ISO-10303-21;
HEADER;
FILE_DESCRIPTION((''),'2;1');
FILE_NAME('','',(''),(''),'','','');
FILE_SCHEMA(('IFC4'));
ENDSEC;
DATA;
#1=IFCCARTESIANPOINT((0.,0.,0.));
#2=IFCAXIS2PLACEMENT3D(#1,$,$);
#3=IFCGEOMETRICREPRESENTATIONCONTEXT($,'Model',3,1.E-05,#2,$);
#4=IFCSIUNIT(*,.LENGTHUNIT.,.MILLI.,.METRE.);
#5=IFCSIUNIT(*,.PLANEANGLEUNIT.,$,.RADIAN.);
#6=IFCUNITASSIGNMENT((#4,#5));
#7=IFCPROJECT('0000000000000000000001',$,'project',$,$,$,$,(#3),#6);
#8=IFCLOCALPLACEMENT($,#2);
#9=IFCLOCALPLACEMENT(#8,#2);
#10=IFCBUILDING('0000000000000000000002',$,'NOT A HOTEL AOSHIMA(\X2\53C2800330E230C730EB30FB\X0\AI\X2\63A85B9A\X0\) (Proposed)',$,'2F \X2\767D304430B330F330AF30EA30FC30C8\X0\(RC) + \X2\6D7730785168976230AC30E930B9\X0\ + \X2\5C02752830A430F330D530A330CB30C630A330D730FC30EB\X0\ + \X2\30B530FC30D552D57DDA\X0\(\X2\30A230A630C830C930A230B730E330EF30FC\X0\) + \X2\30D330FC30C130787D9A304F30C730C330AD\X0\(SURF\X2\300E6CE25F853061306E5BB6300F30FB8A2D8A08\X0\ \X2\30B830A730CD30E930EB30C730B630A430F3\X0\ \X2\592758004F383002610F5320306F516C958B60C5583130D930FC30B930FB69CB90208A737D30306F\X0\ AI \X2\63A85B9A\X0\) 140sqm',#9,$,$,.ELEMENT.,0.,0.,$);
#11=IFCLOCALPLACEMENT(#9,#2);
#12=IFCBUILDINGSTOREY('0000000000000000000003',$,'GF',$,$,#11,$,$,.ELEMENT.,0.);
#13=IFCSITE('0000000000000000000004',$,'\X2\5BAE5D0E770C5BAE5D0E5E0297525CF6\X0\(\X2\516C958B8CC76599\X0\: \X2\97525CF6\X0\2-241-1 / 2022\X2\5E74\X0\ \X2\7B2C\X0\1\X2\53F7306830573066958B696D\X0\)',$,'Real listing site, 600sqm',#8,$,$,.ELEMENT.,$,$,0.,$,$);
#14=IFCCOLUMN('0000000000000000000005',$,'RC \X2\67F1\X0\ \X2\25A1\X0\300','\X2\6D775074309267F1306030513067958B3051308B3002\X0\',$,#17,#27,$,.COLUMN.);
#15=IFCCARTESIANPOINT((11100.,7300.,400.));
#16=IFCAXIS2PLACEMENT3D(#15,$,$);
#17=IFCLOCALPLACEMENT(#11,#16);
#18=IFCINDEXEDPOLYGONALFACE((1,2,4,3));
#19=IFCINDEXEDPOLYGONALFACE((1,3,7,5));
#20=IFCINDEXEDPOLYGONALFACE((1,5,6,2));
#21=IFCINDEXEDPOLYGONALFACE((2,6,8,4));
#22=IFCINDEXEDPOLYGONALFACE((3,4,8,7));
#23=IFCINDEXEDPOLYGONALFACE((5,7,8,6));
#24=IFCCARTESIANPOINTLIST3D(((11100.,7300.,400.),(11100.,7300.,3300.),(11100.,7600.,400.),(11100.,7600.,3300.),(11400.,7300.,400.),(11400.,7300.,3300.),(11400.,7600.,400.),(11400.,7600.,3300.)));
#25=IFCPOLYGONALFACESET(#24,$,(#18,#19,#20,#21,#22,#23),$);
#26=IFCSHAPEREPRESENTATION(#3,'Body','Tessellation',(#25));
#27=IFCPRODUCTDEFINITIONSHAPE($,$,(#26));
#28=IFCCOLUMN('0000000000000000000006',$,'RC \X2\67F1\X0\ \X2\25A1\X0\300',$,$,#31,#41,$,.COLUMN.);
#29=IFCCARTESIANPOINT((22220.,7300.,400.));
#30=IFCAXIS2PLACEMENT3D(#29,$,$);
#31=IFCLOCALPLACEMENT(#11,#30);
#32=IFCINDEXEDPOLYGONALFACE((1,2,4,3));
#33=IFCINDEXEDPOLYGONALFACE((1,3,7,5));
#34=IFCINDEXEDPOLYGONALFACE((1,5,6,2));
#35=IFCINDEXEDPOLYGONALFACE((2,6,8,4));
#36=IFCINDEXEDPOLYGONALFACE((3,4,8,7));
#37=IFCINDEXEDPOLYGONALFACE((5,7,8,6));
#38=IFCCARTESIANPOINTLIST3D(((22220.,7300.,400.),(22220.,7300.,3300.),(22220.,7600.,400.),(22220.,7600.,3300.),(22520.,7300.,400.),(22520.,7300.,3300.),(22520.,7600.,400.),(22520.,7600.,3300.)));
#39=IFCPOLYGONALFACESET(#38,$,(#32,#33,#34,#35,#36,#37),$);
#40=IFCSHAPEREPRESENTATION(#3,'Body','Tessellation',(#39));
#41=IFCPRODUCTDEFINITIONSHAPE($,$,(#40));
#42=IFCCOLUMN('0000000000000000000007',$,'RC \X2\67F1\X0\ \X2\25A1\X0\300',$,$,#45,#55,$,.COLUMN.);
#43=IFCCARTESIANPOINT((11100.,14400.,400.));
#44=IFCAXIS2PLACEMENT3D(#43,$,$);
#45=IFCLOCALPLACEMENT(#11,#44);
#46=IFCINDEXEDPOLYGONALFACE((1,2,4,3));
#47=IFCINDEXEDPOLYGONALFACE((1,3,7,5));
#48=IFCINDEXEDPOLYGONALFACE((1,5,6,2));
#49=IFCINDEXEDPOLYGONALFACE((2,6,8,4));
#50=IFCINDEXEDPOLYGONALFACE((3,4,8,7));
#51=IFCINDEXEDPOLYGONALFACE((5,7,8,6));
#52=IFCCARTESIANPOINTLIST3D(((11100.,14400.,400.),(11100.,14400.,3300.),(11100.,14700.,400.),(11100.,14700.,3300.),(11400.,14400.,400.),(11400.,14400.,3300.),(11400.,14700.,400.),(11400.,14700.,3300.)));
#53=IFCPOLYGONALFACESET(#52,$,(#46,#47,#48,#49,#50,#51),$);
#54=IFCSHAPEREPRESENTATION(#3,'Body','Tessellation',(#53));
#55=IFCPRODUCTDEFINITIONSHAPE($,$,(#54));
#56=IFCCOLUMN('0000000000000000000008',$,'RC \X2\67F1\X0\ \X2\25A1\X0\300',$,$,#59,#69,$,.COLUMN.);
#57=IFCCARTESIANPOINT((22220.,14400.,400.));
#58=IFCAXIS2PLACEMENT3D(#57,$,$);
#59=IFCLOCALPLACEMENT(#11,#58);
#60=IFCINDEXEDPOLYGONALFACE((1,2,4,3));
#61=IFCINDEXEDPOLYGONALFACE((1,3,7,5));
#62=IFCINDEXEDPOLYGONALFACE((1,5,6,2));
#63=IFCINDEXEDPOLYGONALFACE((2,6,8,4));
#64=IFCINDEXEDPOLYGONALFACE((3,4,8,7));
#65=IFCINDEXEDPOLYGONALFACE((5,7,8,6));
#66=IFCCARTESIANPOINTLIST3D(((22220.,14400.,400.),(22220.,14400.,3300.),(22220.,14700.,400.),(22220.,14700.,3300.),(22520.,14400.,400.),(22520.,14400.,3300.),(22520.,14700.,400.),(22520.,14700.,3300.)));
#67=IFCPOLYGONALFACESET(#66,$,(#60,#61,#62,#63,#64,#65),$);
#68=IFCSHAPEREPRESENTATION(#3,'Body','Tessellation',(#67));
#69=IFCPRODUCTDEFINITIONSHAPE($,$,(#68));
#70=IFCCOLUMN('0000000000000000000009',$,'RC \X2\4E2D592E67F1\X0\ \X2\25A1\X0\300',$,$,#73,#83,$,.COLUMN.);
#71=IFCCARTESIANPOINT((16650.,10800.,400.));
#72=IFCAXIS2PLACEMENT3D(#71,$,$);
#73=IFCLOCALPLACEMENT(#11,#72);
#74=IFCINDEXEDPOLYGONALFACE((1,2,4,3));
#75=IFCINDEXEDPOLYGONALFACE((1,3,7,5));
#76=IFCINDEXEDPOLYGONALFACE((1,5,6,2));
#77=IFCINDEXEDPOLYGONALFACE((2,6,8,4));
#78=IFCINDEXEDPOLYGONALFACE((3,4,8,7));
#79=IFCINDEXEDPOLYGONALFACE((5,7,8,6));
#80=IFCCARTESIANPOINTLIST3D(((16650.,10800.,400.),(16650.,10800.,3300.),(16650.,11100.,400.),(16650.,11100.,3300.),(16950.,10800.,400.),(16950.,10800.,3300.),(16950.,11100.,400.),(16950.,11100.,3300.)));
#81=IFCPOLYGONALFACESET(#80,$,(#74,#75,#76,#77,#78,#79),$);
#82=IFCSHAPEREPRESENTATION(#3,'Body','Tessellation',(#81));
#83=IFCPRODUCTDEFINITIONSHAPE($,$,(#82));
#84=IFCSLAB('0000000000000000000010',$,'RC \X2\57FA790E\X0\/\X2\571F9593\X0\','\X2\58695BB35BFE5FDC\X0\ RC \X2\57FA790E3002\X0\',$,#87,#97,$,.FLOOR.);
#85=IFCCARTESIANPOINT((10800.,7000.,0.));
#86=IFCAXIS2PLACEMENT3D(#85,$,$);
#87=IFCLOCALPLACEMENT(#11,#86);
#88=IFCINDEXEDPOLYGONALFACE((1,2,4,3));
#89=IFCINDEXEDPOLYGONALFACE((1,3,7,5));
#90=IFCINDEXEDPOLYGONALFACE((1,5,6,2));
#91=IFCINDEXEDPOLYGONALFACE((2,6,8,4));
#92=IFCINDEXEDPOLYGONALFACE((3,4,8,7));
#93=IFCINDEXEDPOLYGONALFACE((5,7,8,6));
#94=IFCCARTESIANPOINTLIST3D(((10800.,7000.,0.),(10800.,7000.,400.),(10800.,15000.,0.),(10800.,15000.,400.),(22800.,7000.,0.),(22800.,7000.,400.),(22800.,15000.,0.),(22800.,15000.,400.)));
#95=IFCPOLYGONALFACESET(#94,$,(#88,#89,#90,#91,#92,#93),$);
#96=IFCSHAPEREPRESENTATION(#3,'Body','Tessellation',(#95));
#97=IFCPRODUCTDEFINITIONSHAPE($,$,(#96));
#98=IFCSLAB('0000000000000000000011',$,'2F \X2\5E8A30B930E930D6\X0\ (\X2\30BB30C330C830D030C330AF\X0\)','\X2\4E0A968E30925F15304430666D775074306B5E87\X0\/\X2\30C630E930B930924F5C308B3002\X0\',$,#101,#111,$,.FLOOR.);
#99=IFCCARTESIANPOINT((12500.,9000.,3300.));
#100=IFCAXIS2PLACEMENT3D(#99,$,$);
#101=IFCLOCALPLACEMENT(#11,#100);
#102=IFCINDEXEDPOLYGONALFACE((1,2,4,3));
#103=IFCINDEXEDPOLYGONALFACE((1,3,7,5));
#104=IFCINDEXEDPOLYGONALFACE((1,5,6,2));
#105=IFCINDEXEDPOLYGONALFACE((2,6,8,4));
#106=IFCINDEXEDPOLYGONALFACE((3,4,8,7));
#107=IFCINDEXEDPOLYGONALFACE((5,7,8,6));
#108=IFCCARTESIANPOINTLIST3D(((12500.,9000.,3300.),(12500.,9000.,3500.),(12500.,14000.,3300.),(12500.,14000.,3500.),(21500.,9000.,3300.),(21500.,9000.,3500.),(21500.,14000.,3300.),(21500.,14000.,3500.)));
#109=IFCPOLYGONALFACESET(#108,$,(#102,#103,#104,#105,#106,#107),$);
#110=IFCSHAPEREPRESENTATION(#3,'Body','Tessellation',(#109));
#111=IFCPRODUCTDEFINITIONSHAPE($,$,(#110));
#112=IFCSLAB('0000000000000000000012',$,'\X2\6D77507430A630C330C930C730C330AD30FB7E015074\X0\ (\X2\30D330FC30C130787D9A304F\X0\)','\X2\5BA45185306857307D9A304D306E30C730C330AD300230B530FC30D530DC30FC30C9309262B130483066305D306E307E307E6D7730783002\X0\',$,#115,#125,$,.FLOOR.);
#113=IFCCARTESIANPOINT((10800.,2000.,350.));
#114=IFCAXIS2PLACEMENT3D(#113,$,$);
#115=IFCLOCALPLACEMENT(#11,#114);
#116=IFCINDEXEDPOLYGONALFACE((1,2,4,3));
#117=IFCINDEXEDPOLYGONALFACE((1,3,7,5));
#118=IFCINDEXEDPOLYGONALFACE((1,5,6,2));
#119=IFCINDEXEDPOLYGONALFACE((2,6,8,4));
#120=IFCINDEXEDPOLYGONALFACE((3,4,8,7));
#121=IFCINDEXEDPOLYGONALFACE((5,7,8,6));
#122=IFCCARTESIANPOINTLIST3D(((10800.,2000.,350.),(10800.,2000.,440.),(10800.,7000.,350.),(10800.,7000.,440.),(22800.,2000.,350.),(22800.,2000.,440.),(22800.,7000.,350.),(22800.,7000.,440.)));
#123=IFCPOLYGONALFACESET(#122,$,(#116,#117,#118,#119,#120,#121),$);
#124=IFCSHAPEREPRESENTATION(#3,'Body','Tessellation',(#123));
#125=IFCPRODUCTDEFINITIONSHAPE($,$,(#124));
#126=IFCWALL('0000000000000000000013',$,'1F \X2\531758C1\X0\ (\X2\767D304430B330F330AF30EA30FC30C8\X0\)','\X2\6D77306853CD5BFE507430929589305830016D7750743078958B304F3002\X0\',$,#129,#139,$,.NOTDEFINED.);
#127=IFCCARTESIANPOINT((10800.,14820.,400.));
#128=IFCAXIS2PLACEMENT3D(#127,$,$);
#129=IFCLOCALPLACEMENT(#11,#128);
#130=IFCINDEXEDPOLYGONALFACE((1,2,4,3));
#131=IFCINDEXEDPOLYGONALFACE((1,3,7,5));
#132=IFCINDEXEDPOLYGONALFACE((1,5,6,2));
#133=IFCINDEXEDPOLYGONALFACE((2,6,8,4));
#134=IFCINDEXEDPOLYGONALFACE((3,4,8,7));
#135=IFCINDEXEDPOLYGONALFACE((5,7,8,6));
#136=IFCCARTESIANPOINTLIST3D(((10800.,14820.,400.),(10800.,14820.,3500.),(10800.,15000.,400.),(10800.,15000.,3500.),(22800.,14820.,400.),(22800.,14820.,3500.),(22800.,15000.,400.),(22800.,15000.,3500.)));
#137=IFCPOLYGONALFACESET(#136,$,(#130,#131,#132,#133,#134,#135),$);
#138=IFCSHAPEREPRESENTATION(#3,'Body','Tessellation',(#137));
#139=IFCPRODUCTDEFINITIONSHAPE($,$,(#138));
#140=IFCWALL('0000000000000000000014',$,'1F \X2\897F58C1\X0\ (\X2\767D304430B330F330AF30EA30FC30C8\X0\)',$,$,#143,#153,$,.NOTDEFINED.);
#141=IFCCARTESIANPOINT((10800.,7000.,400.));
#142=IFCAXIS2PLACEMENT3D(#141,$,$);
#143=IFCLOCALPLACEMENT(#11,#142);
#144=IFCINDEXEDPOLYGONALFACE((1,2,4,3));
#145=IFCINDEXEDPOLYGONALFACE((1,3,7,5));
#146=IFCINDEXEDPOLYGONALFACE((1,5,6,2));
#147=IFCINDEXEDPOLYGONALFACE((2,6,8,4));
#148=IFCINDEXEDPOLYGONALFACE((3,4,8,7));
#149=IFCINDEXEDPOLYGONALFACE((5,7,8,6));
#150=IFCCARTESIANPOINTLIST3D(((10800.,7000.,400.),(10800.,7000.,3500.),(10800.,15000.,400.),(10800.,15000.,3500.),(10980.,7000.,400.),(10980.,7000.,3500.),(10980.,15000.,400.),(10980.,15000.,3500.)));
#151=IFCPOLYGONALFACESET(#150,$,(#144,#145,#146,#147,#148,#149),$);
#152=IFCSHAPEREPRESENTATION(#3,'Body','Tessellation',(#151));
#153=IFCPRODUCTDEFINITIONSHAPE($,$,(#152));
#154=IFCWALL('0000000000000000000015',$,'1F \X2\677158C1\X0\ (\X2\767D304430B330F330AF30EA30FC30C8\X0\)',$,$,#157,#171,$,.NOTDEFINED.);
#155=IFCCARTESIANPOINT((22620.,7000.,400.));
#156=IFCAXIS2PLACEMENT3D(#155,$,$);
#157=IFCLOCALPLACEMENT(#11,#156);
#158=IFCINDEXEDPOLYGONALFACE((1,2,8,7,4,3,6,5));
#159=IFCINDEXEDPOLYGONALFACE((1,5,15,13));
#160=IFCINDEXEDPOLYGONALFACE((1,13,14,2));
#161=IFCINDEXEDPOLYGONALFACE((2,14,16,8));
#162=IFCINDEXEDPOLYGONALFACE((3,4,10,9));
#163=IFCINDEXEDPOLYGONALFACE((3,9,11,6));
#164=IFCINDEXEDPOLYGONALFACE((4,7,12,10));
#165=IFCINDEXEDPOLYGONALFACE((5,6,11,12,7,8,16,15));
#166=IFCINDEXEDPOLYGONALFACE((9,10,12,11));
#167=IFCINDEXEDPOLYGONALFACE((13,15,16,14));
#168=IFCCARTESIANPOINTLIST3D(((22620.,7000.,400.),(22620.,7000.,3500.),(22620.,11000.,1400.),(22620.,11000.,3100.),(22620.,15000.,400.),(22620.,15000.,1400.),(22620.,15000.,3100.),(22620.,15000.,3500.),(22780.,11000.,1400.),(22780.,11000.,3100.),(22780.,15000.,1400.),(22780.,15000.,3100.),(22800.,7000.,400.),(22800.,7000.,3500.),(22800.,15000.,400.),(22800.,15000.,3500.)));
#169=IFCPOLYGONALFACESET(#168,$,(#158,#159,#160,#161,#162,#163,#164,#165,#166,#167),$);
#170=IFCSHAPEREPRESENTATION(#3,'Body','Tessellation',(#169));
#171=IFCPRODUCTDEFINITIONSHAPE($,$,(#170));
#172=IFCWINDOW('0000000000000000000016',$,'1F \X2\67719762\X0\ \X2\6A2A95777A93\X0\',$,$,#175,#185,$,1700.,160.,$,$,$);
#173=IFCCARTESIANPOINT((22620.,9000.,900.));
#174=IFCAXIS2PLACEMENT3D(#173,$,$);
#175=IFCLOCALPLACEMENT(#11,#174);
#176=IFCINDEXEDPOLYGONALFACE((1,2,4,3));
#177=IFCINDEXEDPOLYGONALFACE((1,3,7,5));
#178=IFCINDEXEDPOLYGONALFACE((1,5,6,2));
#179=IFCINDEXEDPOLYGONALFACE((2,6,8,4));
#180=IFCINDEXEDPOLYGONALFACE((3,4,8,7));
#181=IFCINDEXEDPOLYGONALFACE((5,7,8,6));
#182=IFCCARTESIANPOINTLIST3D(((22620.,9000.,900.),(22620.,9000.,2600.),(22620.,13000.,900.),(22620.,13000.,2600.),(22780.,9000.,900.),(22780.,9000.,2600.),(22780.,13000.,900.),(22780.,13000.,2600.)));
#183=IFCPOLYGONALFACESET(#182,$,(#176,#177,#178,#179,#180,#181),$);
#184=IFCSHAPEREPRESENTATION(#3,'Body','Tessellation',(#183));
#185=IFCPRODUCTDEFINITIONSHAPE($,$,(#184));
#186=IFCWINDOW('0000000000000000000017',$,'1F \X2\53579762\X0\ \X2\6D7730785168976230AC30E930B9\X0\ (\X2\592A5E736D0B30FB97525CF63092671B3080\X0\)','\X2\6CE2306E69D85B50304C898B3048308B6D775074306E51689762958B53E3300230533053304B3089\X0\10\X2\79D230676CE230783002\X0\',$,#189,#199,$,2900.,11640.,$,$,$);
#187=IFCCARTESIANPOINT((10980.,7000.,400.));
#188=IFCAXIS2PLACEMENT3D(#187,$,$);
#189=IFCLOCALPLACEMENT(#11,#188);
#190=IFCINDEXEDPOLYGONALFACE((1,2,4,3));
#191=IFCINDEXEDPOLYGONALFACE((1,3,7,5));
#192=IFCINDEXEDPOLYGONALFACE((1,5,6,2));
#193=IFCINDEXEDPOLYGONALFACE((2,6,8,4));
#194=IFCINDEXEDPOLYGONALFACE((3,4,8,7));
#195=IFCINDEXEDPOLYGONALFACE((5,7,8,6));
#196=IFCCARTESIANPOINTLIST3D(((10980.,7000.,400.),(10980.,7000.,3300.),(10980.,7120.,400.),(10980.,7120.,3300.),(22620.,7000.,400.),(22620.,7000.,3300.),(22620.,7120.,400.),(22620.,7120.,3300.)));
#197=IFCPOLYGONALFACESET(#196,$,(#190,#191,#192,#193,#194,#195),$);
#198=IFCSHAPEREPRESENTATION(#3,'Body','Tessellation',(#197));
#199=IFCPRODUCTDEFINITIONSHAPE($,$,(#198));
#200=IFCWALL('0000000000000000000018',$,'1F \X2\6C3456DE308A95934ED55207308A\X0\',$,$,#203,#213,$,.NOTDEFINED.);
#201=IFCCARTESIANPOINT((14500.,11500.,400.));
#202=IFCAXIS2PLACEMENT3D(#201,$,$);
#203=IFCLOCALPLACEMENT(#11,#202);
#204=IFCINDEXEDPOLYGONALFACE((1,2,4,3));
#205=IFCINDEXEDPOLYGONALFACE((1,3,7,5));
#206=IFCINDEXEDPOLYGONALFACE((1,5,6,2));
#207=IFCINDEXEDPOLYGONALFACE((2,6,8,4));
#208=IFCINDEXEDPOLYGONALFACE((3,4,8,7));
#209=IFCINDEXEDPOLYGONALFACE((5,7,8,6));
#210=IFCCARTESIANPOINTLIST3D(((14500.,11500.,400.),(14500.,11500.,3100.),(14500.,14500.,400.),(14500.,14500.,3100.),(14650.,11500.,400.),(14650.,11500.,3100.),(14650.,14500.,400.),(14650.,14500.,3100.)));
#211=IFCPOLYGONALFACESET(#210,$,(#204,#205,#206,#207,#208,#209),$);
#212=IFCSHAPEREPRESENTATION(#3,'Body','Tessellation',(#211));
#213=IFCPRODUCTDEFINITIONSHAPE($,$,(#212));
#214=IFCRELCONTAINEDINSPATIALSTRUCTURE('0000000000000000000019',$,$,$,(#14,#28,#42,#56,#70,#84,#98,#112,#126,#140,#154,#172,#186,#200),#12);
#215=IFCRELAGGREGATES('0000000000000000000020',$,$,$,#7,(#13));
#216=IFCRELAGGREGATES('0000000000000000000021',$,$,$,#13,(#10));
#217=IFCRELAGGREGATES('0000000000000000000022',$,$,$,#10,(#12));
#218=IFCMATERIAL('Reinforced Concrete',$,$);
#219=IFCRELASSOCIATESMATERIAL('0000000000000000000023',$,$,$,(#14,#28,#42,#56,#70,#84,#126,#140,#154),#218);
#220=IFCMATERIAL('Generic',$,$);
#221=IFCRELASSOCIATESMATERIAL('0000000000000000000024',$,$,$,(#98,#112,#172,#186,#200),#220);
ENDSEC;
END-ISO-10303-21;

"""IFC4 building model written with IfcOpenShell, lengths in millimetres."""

from ifc_helpers import new_model, si_unit, frame, frame_2d, origin, place, context, project, spatial, rectangle, extrude, material, element, fill, save


model = new_model("IFC4")

# Units and contexts
model_context = context("Model", 3, precision=1e-05, world=origin())
ifc_project = project(units=[si_unit("LENGTHUNIT", "METRE", prefix="MILLI"), si_unit("PLANEANGLEUNIT", "RADIAN")], contexts=[model_context])

# Site, building, storey
site_placement = place(None, origin())
site = spatial("IfcSite", under=ifc_project, at=site_placement, Name="宮崎県宮崎市青島(公開資料: 青島2-241-1 / 2022年 第1号として開業)", ObjectType="Real listing site, 600sqm", CompositionType="ELEMENT", RefElevation=0.0)
building_placement = place(site_placement, origin())
building = spatial("IfcBuilding", under=site, at=building_placement, Name="NOT A HOTEL AOSHIMA(参考モデル・AI推定) (Proposed)", ObjectType="2F 白いコンクリート(RC) + 海へ全面ガラス + 専用インフィニティプール + サーフ動線(アウトドアシャワー) + ビーチへ続くデッキ(SURF『波待ちの家』・設計 ジェネラルデザイン 大堀伸。意匠は公開情報ベース・構造詳細は AI 推定) 140sqm", CompositionType="ELEMENT", ElevationOfRefHeight=0.0, ElevationOfTerrain=0.0)
storey_placement = place(building_placement, origin())
storey = spatial("IfcBuildingStorey", under=building, at=storey_placement, Name="GF", CompositionType="ELEMENT", Elevation=0.0)

# Columns
ifc_material_1 = material(Name="Reinforced Concrete")
column_1_placement = place(storey_placement, frame((11100.0, 7300.0, 400.0)))
element("IfcColumn", 1, at=column_1_placement, inside=storey, material=ifc_material_1, Name="RC 柱 □300", Description="海側を柱だけで開ける。", PredefinedType="COLUMN", context=model_context, shape_type="SweptSolid", body=[
    extrude(rectangle(XDim=300.0, YDim=300.0, at=frame_2d((150.0, 150.0))), frame((11100.0, 7300.0, 400.0)), (0.0, 0.0, 1.0), 2900.0),
])
column_2_placement = place(storey_placement, frame((22220.0, 7300.0, 400.0)))
element("IfcColumn", 2, at=column_2_placement, inside=storey, material=ifc_material_1, Name="RC 柱 □300", PredefinedType="COLUMN", context=model_context, shape_type="SweptSolid", body=[
    extrude(rectangle(XDim=300.0, YDim=300.0, at=frame_2d((150.0, 150.0))), frame((22220.0, 7300.0, 400.0)), (0.0, 0.0, 1.0), 2900.0),
])
column_3_placement = place(storey_placement, frame((11100.0, 14400.0, 400.0)))
element("IfcColumn", 3, at=column_3_placement, inside=storey, material=ifc_material_1, Name="RC 柱 □300", PredefinedType="COLUMN", context=model_context, shape_type="SweptSolid", body=[
    extrude(rectangle(XDim=300.0, YDim=300.0, at=frame_2d((150.0, 150.0))), frame((11100.0, 14400.0, 400.0)), (0.0, 0.0, 1.0), 2900.0),
])
column_4_placement = place(storey_placement, frame((22220.0, 14400.0, 400.0)))
element("IfcColumn", 4, at=column_4_placement, inside=storey, material=ifc_material_1, Name="RC 柱 □300", PredefinedType="COLUMN", context=model_context, shape_type="SweptSolid", body=[
    extrude(rectangle(XDim=300.0, YDim=300.0, at=frame_2d((150.0, 150.0))), frame((22220.0, 14400.0, 400.0)), (0.0, 0.0, 1.0), 2900.0),
])
column_5_placement = place(storey_placement, frame((16650.0, 10800.0, 400.0)))
element("IfcColumn", 5, at=column_5_placement, inside=storey, material=ifc_material_1, Name="RC 中央柱 □300", PredefinedType="COLUMN", context=model_context, shape_type="SweptSolid", body=[
    extrude(rectangle(XDim=300.0, YDim=300.0, at=frame_2d((150.0, 150.0))), frame((16650.0, 10800.0, 400.0)), (0.0, 0.0, 1.0), 2900.0),
])

# Slabs
slab_1_placement = place(storey_placement, frame((10800.0, 7000.0, 0.0)))
element("IfcSlab", 6, at=slab_1_placement, inside=storey, material=ifc_material_1, Name="RC 基礎/土間", Description="塩害対応 RC 基礎。", PredefinedType="FLOOR", context=model_context, shape_type="SweptSolid", body=[
    extrude(rectangle(XDim=12000.0, YDim=8000.0, at=frame_2d((6000.0, 4000.0))), frame((10800.0, 7000.0, 0.0)), (0.0, 0.0, 1.0), 400.0),
])
ifc_material_2 = material(Name="Generic")
slab_2_placement = place(storey_placement, frame((12500.0, 9000.0, 3300.0)))
element("IfcSlab", 7, at=slab_2_placement, inside=storey, material=ifc_material_2, Name="2F 床スラブ (セットバック)", Description="上階を引いて海側に庇/テラスを作る。", PredefinedType="FLOOR", context=model_context, shape_type="SweptSolid", body=[
    extrude(rectangle(XDim=9000.0, YDim=5000.0, at=frame_2d((4500.0, 2500.0))), frame((12500.0, 9000.0, 3300.0)), (0.0, 0.0, 1.0), 200.0),
])
slab_3_placement = place(storey_placement, frame((10800.0, 2000.0, 350.0)))
element("IfcSlab", 8, at=slab_3_placement, inside=storey, material=ifc_material_2, Name="海側ウッドデッキ・縁側 (ビーチへ続く)", Description="室内と地続きのデッキ。サーフボードを抱えてそのまま海へ。", PredefinedType="FLOOR", context=model_context, shape_type="SweptSolid", body=[
    extrude(rectangle(XDim=12000.0, YDim=5000.0, at=frame_2d((6000.0, 2500.0))), frame((10800.0, 2000.0, 350.0)), (0.0, 0.0, 1.0), 90.0),
])

# Walls
wall_1_placement = place(storey_placement, frame((10800.0, 14820.0, 400.0)))
element("IfcWall", 9, at=wall_1_placement, inside=storey, material=ifc_material_1, Name="1F 北壁 (白いコンクリート)", Description="海と反対側を閉じ、海側へ開く。", PredefinedType="NOTDEFINED", context=model_context, shape_type="SweptSolid", body=[
    extrude(rectangle(XDim=12000.0, YDim=180.0, at=frame_2d((6000.0, 90.0))), frame((10800.0, 14820.0, 400.0)), (0.0, 0.0, 1.0), 3100.0),
])
wall_2_placement = place(storey_placement, frame((10800.0, 7000.0, 400.0)))
element("IfcWall", 10, at=wall_2_placement, inside=storey, material=ifc_material_1, Name="1F 西壁 (白いコンクリート)", PredefinedType="NOTDEFINED", context=model_context, shape_type="SweptSolid", body=[
    extrude(rectangle(XDim=180.0, YDim=8000.0, at=frame_2d((90.0, 4000.0))), frame((10800.0, 7000.0, 400.0)), (0.0, 0.0, 1.0), 3100.0),
])

# Wall, opening, window
wall_3_placement = place(storey_placement, frame((22620.0, 7000.0, 400.0)))
wall_3 = element("IfcWall", 11, at=wall_3_placement, inside=storey, material=ifc_material_1, Name="1F 東壁 (白いコンクリート)", PredefinedType="NOTDEFINED", context=model_context, shape_type="SweptSolid", body=[
    extrude(rectangle(XDim=180.0, YDim=8000.0, at=frame_2d((90.0, 4000.0))), frame((22620.0, 7000.0, 400.0)), (0.0, 0.0, 1.0), 3100.0),
])
opening_placement = place(storey_placement, frame((22620.0, 9000.0, 900.0)))
opening = element("IfcOpeningElement", 12, at=opening_placement, cuts=wall_3, PredefinedType="NOTDEFINED", context=model_context, shape_type="SweptSolid", body=[
    extrude(rectangle(XDim=160.0, YDim=4000.0, at=frame_2d((80.0, 2000.0))), frame((22620.0, 9000.0, 900.0)), (0.0, 0.0, 1.0), 1700.0),
])
window_1_placement = place(storey_placement, frame((22620.0, 9000.0, 900.0)))
window_1 = element("IfcWindow", 13, at=window_1_placement, inside=storey, material=ifc_material_2, Name="1F 東面 横長窓", OverallHeight=1700.0, OverallWidth=160.0, context=model_context, shape_type="SweptSolid", body=[
    extrude(rectangle(XDim=160.0, YDim=4000.0, at=frame_2d((80.0, 2000.0))), frame((22620.0, 9000.0, 900.0)), (0.0, 0.0, 1.0), 1700.0),
])
fill(opening, window_1)

# Window
window_2_placement = place(storey_placement, frame((10980.0, 7000.0, 400.0)))
element("IfcWindow", 14, at=window_2_placement, inside=storey, material=ifc_material_2, Name="1F 南面 海へ全面ガラス (太平洋・青島を望む)", Description="波の様子が見える海側の全面開口。ここから10秒で波へ。", OverallHeight=2900.0, OverallWidth=11640.0, context=model_context, shape_type="SweptSolid", body=[
    extrude(rectangle(XDim=11640.0, YDim=120.0, at=frame_2d((5820.0, 60.0))), frame((10980.0, 7000.0, 400.0)), (0.0, 0.0, 1.0), 2900.0),
])

# Wall
wall_4_placement = place(storey_placement, frame((14500.0, 11500.0, 400.0)))
element("IfcWall", 15, at=wall_4_placement, inside=storey, material=ifc_material_2, Name="1F 水回り間仕切り", PredefinedType="NOTDEFINED", context=model_context, shape_type="SweptSolid", body=[
    extrude(rectangle(XDim=150.0, YDim=3000.0, at=frame_2d((75.0, 1500.0))), frame((14500.0, 11500.0, 400.0)), (0.0, 0.0, 1.0), 2700.0),
])

save(model, "model.ifc")
